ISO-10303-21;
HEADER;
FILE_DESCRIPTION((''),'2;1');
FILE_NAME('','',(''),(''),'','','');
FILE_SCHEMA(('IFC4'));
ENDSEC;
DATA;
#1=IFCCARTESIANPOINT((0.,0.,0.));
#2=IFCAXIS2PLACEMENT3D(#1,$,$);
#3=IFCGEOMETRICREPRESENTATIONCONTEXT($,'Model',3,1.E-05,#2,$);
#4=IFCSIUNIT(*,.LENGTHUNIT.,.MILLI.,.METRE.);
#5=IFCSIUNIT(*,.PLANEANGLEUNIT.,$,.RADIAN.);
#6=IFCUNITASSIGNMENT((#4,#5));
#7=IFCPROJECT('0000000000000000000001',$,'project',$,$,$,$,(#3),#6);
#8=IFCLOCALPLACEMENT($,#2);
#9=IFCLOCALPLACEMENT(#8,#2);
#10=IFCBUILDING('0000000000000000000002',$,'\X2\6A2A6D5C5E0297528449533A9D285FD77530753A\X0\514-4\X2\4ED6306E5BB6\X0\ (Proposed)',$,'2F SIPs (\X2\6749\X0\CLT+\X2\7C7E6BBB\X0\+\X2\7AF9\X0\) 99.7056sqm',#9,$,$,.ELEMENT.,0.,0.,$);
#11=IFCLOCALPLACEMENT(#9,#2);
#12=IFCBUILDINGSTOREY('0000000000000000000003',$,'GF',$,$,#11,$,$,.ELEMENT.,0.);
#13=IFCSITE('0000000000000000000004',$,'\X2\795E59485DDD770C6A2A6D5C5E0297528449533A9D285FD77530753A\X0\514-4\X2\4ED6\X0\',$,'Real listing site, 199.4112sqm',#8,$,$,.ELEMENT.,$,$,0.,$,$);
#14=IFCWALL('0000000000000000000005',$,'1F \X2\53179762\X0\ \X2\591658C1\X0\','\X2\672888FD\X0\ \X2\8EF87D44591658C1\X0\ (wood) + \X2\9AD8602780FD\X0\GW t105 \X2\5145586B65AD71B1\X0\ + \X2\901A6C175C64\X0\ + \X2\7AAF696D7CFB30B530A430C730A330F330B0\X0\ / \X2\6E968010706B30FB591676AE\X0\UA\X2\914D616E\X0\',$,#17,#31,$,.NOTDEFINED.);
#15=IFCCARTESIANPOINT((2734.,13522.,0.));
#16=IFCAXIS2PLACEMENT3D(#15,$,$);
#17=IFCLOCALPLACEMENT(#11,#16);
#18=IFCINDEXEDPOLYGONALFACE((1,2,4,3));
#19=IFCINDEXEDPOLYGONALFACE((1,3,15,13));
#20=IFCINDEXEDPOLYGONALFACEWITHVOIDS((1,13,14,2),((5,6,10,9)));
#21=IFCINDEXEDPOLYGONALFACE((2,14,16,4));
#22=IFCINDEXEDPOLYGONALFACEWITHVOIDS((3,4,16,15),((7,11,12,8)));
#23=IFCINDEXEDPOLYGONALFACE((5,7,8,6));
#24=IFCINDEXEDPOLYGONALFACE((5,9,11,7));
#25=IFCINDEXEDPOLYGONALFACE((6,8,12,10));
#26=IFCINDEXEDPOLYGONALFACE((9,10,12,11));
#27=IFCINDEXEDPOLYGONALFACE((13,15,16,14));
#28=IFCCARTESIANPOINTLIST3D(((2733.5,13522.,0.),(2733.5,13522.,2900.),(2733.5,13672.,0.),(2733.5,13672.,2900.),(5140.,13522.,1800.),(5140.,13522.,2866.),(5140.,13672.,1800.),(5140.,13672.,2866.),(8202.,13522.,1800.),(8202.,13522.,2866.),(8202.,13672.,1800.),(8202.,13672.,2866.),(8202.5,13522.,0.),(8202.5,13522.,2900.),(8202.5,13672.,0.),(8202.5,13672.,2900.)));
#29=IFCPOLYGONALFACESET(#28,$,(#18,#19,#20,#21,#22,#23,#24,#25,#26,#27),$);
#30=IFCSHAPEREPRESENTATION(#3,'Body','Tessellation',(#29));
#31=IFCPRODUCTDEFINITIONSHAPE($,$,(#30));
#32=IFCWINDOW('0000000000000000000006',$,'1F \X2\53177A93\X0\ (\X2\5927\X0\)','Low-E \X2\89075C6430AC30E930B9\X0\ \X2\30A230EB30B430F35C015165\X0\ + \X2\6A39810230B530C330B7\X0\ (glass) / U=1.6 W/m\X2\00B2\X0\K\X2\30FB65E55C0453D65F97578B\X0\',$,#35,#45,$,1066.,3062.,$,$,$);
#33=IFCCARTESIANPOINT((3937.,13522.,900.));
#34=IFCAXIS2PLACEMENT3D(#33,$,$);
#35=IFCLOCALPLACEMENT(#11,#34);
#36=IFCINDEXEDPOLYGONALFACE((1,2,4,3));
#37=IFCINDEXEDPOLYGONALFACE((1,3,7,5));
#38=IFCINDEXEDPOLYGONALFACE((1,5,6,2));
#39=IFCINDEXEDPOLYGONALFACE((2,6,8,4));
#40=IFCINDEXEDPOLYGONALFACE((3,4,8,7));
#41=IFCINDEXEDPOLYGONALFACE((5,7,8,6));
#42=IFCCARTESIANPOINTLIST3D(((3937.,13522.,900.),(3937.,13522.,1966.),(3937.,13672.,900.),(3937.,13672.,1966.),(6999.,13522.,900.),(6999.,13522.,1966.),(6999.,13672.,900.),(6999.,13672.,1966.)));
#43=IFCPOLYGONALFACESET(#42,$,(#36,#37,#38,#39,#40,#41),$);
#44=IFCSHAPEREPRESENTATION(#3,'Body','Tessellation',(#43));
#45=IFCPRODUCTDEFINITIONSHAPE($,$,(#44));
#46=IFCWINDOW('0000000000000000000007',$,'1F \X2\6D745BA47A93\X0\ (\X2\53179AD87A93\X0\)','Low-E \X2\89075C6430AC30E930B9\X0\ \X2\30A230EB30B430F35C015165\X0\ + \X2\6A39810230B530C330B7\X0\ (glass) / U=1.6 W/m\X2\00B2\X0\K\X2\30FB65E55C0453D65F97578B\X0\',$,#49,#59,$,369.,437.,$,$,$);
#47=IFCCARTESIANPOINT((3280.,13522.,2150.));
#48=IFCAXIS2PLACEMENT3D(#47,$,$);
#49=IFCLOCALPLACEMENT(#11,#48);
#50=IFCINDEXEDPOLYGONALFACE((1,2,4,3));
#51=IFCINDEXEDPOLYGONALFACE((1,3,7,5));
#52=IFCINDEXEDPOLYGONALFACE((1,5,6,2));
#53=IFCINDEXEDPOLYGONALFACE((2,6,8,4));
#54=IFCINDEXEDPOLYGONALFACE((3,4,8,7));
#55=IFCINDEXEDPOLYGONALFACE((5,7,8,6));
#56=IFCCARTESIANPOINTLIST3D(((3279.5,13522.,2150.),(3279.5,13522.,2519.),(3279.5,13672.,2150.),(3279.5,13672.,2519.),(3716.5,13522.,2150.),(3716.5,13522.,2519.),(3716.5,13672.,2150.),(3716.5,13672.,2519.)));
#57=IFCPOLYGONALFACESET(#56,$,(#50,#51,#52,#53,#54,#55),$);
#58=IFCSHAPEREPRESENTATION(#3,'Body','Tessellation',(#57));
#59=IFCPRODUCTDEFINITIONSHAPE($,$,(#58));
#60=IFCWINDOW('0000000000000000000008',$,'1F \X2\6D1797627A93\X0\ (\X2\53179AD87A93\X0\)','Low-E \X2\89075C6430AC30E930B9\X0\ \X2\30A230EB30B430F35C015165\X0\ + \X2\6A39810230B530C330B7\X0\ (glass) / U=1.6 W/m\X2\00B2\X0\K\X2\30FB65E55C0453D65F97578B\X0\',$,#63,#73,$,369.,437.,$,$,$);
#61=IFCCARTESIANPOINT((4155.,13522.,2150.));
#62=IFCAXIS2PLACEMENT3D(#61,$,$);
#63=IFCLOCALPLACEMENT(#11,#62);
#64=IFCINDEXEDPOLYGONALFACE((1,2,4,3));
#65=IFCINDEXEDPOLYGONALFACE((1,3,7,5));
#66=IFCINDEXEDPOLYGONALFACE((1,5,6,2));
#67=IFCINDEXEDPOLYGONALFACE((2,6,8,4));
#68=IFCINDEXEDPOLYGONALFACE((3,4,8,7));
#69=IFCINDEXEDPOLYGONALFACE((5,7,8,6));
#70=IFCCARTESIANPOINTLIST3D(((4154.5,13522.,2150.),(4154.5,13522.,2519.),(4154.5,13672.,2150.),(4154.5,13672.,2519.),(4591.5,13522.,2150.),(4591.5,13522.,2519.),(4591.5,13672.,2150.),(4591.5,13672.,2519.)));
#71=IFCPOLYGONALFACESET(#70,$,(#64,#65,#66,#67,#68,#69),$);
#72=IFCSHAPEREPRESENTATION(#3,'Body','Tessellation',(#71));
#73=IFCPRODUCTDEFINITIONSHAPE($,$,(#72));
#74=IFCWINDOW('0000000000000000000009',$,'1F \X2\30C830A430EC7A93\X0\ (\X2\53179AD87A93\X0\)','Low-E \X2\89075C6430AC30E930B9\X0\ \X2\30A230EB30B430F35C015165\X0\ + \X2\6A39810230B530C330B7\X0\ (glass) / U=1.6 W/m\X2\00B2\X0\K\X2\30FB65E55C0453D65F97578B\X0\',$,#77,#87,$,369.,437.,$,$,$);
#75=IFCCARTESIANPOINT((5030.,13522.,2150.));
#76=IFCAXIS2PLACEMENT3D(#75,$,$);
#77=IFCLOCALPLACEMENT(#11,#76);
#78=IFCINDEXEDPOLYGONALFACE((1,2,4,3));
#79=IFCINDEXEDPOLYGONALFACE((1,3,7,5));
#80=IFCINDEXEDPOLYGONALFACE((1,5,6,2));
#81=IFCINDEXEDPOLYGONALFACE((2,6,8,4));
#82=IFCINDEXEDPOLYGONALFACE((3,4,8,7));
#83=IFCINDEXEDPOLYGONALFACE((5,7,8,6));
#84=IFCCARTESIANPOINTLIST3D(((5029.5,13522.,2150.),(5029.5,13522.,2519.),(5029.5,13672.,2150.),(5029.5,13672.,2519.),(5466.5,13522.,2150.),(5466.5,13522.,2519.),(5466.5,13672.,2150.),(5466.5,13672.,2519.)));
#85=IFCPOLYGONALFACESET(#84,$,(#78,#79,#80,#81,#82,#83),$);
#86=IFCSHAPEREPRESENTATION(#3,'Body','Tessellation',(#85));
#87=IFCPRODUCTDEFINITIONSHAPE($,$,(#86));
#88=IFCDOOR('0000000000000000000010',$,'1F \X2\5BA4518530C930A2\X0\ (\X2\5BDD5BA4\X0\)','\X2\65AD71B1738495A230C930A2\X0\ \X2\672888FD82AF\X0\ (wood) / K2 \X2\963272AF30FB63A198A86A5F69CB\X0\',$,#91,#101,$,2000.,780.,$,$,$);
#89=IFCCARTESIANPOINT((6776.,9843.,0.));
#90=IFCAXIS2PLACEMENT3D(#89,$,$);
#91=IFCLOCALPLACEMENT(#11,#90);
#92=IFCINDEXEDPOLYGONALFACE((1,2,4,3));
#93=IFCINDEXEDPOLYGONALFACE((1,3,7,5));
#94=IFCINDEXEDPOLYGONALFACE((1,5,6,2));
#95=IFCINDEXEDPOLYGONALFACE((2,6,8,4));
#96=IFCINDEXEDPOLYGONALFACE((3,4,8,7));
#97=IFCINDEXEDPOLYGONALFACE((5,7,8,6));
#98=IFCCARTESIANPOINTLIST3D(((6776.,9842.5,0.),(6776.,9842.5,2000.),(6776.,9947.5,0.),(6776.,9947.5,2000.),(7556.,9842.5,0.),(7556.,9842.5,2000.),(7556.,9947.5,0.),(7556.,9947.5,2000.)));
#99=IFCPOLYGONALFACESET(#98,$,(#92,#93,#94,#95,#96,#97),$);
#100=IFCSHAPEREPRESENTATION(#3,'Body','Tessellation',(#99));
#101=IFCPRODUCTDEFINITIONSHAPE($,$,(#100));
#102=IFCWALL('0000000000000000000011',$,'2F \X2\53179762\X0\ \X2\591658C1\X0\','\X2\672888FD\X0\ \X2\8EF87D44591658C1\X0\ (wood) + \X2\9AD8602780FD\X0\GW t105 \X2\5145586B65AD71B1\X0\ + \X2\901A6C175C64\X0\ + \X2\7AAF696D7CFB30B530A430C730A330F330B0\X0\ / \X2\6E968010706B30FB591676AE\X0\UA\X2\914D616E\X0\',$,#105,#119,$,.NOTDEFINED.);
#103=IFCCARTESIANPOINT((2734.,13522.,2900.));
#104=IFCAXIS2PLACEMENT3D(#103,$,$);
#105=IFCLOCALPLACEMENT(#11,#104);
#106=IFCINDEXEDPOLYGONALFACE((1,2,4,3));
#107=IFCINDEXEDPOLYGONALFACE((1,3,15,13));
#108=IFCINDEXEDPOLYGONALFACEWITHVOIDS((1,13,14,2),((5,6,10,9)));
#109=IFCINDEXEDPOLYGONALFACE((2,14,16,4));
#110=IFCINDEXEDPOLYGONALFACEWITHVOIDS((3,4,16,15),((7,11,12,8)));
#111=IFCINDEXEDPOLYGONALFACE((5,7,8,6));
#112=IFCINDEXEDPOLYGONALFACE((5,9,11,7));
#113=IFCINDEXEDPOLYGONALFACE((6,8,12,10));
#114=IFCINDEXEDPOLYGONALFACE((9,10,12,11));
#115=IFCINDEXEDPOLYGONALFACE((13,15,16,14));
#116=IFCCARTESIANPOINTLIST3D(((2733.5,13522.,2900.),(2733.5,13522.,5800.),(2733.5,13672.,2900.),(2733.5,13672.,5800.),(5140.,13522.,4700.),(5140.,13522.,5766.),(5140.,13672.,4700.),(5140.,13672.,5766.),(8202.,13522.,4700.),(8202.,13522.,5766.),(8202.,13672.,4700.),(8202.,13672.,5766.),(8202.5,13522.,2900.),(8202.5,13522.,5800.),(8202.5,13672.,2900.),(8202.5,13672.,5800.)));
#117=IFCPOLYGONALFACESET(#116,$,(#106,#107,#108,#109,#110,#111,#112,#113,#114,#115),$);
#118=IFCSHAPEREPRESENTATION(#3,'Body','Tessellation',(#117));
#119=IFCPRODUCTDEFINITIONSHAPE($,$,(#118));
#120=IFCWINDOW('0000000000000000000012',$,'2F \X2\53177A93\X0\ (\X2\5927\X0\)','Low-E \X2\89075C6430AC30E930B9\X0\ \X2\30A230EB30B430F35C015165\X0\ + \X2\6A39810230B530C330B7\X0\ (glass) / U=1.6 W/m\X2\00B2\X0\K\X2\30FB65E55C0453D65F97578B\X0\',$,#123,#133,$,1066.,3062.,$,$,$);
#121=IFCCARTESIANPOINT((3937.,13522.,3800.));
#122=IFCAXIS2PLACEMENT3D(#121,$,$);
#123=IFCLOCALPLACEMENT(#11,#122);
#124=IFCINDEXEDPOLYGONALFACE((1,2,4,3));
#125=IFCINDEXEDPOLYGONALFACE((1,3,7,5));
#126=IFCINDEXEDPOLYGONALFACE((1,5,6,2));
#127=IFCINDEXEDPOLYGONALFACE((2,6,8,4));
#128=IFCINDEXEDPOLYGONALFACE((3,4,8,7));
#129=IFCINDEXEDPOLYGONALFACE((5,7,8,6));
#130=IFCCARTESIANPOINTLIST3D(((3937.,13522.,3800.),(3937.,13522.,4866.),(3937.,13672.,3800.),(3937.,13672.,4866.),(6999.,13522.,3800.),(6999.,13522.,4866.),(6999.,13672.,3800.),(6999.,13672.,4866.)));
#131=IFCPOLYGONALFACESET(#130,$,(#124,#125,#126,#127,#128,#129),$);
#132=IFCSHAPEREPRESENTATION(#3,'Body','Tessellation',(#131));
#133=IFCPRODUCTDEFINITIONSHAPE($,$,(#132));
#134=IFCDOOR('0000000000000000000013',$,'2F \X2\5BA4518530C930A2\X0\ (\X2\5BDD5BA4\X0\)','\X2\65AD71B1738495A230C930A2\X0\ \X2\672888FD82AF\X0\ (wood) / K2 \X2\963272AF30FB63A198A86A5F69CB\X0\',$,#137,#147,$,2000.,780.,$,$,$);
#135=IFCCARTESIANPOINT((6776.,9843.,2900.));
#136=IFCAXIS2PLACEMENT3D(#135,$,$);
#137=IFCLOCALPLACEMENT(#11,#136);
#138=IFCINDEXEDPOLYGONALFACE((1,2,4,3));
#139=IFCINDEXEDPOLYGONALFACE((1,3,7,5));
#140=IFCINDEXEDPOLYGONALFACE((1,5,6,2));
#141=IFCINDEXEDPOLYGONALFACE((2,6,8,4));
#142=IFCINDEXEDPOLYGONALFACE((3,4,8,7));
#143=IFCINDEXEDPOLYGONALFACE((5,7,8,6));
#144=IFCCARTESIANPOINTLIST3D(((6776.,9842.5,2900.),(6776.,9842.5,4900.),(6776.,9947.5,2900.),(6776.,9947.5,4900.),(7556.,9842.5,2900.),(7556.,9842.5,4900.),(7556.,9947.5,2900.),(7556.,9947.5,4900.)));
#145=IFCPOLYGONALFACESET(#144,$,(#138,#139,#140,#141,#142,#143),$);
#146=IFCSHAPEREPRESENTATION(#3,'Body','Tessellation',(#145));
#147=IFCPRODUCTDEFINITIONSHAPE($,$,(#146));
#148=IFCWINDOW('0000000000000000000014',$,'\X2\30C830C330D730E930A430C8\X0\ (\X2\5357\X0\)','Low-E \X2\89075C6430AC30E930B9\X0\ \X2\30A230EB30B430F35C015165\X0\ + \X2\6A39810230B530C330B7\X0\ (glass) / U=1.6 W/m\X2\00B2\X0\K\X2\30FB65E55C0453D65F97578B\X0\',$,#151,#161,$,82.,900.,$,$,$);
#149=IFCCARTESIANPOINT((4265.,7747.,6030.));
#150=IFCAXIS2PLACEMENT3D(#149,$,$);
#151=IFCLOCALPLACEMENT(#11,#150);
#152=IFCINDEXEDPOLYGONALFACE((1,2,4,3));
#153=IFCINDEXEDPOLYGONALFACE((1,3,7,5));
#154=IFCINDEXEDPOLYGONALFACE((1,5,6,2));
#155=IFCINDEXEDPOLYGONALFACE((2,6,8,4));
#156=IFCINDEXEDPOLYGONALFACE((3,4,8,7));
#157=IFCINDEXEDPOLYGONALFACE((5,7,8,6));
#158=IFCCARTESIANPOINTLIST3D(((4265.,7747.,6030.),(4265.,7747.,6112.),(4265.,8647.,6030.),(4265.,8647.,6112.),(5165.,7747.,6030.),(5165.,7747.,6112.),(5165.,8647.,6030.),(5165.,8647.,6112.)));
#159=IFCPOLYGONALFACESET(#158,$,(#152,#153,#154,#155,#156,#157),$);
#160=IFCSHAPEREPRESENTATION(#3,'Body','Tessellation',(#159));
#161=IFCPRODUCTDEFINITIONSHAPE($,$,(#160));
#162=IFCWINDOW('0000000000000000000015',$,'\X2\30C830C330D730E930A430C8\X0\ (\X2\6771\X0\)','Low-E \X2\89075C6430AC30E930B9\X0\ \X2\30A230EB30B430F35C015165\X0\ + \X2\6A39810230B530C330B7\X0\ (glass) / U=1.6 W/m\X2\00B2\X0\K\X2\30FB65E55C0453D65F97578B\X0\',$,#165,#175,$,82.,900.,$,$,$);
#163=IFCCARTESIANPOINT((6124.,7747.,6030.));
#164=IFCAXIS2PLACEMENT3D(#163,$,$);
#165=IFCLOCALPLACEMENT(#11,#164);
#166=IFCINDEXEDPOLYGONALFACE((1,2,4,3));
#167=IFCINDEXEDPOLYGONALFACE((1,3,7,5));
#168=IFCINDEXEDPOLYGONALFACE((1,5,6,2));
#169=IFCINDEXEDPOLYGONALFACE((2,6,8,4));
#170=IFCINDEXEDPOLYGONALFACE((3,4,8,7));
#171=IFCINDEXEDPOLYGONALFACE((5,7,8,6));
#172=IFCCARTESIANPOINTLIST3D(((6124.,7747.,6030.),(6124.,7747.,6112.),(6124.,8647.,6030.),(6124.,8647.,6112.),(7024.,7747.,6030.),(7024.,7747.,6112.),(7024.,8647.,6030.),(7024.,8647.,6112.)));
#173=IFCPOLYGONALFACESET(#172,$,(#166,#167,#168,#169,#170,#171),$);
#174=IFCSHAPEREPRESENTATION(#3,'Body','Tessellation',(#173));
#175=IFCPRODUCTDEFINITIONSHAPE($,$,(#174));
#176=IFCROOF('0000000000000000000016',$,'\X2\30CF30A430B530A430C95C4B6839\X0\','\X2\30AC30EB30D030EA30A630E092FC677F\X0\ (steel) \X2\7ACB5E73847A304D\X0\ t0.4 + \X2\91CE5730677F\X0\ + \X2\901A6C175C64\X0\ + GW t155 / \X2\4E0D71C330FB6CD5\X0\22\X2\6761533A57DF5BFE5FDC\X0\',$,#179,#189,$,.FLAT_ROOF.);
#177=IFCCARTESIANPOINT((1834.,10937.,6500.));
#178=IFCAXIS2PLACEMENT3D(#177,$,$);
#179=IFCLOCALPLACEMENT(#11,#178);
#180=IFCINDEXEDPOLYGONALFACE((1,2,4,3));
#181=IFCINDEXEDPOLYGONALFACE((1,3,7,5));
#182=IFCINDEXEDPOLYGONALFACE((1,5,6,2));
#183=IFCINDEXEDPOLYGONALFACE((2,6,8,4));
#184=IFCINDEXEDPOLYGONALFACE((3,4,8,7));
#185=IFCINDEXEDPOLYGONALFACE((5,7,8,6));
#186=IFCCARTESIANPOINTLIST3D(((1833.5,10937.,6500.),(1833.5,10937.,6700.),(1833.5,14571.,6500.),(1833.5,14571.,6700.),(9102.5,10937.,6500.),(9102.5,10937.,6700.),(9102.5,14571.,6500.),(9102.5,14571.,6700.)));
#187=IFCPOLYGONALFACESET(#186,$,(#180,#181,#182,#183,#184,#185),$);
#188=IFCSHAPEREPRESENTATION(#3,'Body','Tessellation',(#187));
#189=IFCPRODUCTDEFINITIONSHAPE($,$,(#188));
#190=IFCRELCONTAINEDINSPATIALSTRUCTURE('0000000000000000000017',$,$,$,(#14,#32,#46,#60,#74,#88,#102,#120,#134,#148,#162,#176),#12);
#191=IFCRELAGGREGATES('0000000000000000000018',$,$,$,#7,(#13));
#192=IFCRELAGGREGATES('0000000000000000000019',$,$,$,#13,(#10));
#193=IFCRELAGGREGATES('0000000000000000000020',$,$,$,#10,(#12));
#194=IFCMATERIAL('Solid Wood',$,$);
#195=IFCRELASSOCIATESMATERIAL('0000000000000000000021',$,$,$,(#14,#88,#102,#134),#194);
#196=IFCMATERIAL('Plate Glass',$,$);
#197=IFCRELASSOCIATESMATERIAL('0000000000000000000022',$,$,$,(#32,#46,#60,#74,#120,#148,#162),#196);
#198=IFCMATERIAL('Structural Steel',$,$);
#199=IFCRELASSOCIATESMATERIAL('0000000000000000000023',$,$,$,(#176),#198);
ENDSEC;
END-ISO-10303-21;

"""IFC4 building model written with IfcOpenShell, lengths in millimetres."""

from ifc_helpers import new_model, si_unit, frame, frame_2d, origin, place, context, project, spatial, rectangle, extrude, material, element, fill, save


model = new_model("IFC4")

# Units and contexts
model_context = context("Model", 3, precision=1e-05, world=origin())
ifc_project = project(units=[si_unit("LENGTHUNIT", "METRE", prefix="MILLI"), si_unit("PLANEANGLEUNIT", "RADIAN")], contexts=[model_context])

# Site, building, storey
site_placement = place(None, origin())
site = spatial("IfcSite", under=ifc_project, at=site_placement, Name="神奈川県横浜市青葉区鴨志田町514-4他", ObjectType="Real listing site, 199.4112sqm", CompositionType="ELEMENT", RefElevation=0.0)
building_placement = place(site_placement, origin())
building = spatial("IfcBuilding", under=site, at=building_placement, Name="横浜市青葉区鴨志田町514-4他の家 (Proposed)", ObjectType="2F SIPs (杉CLT+籾殻+竹) 99.7056sqm", CompositionType="ELEMENT", ElevationOfRefHeight=0.0, ElevationOfTerrain=0.0)
storey_placement = place(building_placement, origin())
storey = spatial("IfcBuildingStorey", under=building, at=storey_placement, Name="GF", CompositionType="ELEMENT", Elevation=0.0)

# Wall, openings, windows
ifc_material_1 = material(Name="Solid Wood")
wall_1_placement = place(storey_placement, frame((2734.0, 13522.0, 0.0)))
wall_1 = element("IfcWall", 1, at=wall_1_placement, inside=storey, material=ifc_material_1, Name="1F 北面 外壁", Description="木製 軸組外壁 (wood) + 高性能GW t105 充填断熱 + 通気層 + 窯業系サイディング / 準耐火・外皮UA配慮", PredefinedType="NOTDEFINED", context=model_context, shape_type="SweptSolid", body=[
    extrude(rectangle(XDim=5469.0, YDim=150.0, at=frame_2d((2734.0, 75.0))), frame((2734.0, 13522.0, 0.0)), (0.0, 0.0, 1.0), 2900.0),
])
opening_1_placement = place(storey_placement, frame((3937.0, 13522.0, 900.0)))
opening_1 = element("IfcOpeningElement", 2, at=opening_1_placement, cuts=wall_1, PredefinedType="NOTDEFINED", context=model_context, shape_type="SweptSolid", body=[
    extrude(rectangle(XDim=3062.0, YDim=150.0, at=frame_2d((1531.0, 75.0))), frame((3937.0, 13522.0, 900.0)), (0.0, 0.0, 1.0), 1066.0),
])
opening_2_placement = place(storey_placement, frame((3280.0, 13522.0, 2150.0)))
opening_2 = element("IfcOpeningElement", 3, at=opening_2_placement, cuts=wall_1, PredefinedType="NOTDEFINED", context=model_context, shape_type="SweptSolid", body=[
    extrude(rectangle(XDim=437.0, YDim=150.0, at=frame_2d((218.0, 75.0))), frame((3280.0, 13522.0, 2150.0)), (0.0, 0.0, 1.0), 369.0),
])
opening_3_placement = place(storey_placement, frame((4155.0, 13522.0, 2150.0)))
opening_3 = element("IfcOpeningElement", 4, at=opening_3_placement, cuts=wall_1, PredefinedType="NOTDEFINED", context=model_context, shape_type="SweptSolid", body=[
    extrude(rectangle(XDim=437.0, YDim=150.0, at=frame_2d((218.0, 75.0))), frame((4155.0, 13522.0, 2150.0)), (0.0, 0.0, 1.0), 369.0),
])
opening_4_placement = place(storey_placement, frame((5030.0, 13522.0, 2150.0)))
opening_4 = element("IfcOpeningElement", 5, at=opening_4_placement, cuts=wall_1, PredefinedType="NOTDEFINED", context=model_context, shape_type="SweptSolid", body=[
    extrude(rectangle(XDim=437.0, YDim=150.0, at=frame_2d((218.0, 75.0))), frame((5030.0, 13522.0, 2150.0)), (0.0, 0.0, 1.0), 369.0),
])
ifc_material_2 = material(Name="Plate Glass")
window_1_placement = place(storey_placement, frame((3937.0, 13522.0, 900.0)))
window_1 = element("IfcWindow", 6, at=window_1_placement, inside=storey, material=ifc_material_2, Name="1F 北窓 (大)", Description="Low-E 複層ガラス アルゴン封入 + 樹脂サッシ (glass) / U=1.6 W/m²K・日射取得型", OverallHeight=1066.0, OverallWidth=3062.0, context=model_context, shape_type="SweptSolid", body=[
    extrude(rectangle(XDim=3062.0, YDim=150.0, at=frame_2d((1531.0, 75.0))), frame((3937.0, 13522.0, 900.0)), (0.0, 0.0, 1.0), 1066.0),
])
fill(opening_1, window_1)
window_2_placement = place(storey_placement, frame((3280.0, 13522.0, 2150.0)))
window_2 = element("IfcWindow", 7, at=window_2_placement, inside=storey, material=ifc_material_2, Name="1F 浴室窓 (北高窓)", Description="Low-E 複層ガラス アルゴン封入 + 樹脂サッシ (glass) / U=1.6 W/m²K・日射取得型", OverallHeight=369.0, OverallWidth=437.0, context=model_context, shape_type="SweptSolid", body=[
    extrude(rectangle(XDim=437.0, YDim=150.0, at=frame_2d((218.0, 75.0))), frame((3280.0, 13522.0, 2150.0)), (0.0, 0.0, 1.0), 369.0),
])
fill(opening_2, window_2)
window_3_placement = place(storey_placement, frame((4155.0, 13522.0, 2150.0)))
window_3 = element("IfcWindow", 8, at=window_3_placement, inside=storey, material=ifc_material_2, Name="1F 洗面窓 (北高窓)", Description="Low-E 複層ガラス アルゴン封入 + 樹脂サッシ (glass) / U=1.6 W/m²K・日射取得型", OverallHeight=369.0, OverallWidth=437.0, context=model_context, shape_type="SweptSolid", body=[
    extrude(rectangle(XDim=437.0, YDim=150.0, at=frame_2d((218.0, 75.0))), frame((4155.0, 13522.0, 2150.0)), (0.0, 0.0, 1.0), 369.0),
])
fill(opening_3, window_3)
window_4_placement = place(storey_placement, frame((5030.0, 13522.0, 2150.0)))
window_4 = element("IfcWindow", 9, at=window_4_placement, inside=storey, material=ifc_material_2, Name="1F トイレ窓 (北高窓)", Description="Low-E 複層ガラス アルゴン封入 + 樹脂サッシ (glass) / U=1.6 W/m²K・日射取得型", OverallHeight=369.0, OverallWidth=437.0, context=model_context, shape_type="SweptSolid", body=[
    extrude(rectangle(XDim=437.0, YDim=150.0, at=frame_2d((218.0, 75.0))), frame((5030.0, 13522.0, 2150.0)), (0.0, 0.0, 1.0), 369.0),
])
fill(opening_4, window_4)

# Door
door_1_placement = place(storey_placement, frame((6776.0, 9843.0, 0.0)))
element("IfcDoor", 10, at=door_1_placement, inside=storey, material=ifc_material_1, Name="1F 室内ドア (寝室)", Description="断熱玄関ドア 木製芯 (wood) / K2 防犯・採風機構", OverallHeight=2000.0, OverallWidth=780.0, context=model_context, shape_type="SweptSolid", body=[
    extrude(rectangle(XDim=780.0, YDim=105.0, at=frame_2d((390.0, 52.0))), frame((6776.0, 9843.0, 0.0)), (0.0, 0.0, 1.0), 2000.0),
])

# Wall, opening, window
wall_2_placement = place(storey_placement, frame((2734.0, 13522.0, 2900.0)))
wall_2 = element("IfcWall", 11, at=wall_2_placement, inside=storey, material=ifc_material_1, Name="2F 北面 外壁", Description="木製 軸組外壁 (wood) + 高性能GW t105 充填断熱 + 通気層 + 窯業系サイディング / 準耐火・外皮UA配慮", PredefinedType="NOTDEFINED", context=model_context, shape_type="SweptSolid", body=[
    extrude(rectangle(XDim=5469.0, YDim=150.0, at=frame_2d((2734.0, 75.0))), frame((2734.0, 13522.0, 2900.0)), (0.0, 0.0, 1.0), 2900.0),
])
opening_5_placement = place(storey_placement, frame((3937.0, 13522.0, 3800.0)))
opening_5 = element("IfcOpeningElement", 12, at=opening_5_placement, cuts=wall_2, PredefinedType="NOTDEFINED", context=model_context, shape_type="SweptSolid", body=[
    extrude(rectangle(XDim=3062.0, YDim=150.0, at=frame_2d((1531.0, 75.0))), frame((3937.0, 13522.0, 3800.0)), (0.0, 0.0, 1.0), 1066.0),
])
window_5_placement = place(storey_placement, frame((3937.0, 13522.0, 3800.0)))
window_5 = element("IfcWindow", 13, at=window_5_placement, inside=storey, material=ifc_material_2, Name="2F 北窓 (大)", Description="Low-E 複層ガラス アルゴン封入 + 樹脂サッシ (glass) / U=1.6 W/m²K・日射取得型", OverallHeight=1066.0, OverallWidth=3062.0, context=model_context, shape_type="SweptSolid", body=[
    extrude(rectangle(XDim=3062.0, YDim=150.0, at=frame_2d((1531.0, 75.0))), frame((3937.0, 13522.0, 3800.0)), (0.0, 0.0, 1.0), 1066.0),
])
fill(opening_5, window_5)

# Door
door_2_placement = place(storey_placement, frame((6776.0, 9843.0, 2900.0)))
element("IfcDoor", 14, at=door_2_placement, inside=storey, material=ifc_material_1, Name="2F 室内ドア (寝室)", Description="断熱玄関ドア 木製芯 (wood) / K2 防犯・採風機構", OverallHeight=2000.0, OverallWidth=780.0, context=model_context, shape_type="SweptSolid", body=[
    extrude(rectangle(XDim=780.0, YDim=105.0, at=frame_2d((390.0, 52.0))), frame((6776.0, 9843.0, 2900.0)), (0.0, 0.0, 1.0), 2000.0),
])

# Windows
window_6_placement = place(storey_placement, frame((4265.0, 7747.0, 6030.0)))
element("IfcWindow", 15, at=window_6_placement, inside=storey, material=ifc_material_2, Name="トップライト (南)", Description="Low-E 複層ガラス アルゴン封入 + 樹脂サッシ (glass) / U=1.6 W/m²K・日射取得型", OverallHeight=82.0, OverallWidth=900.0, context=model_context, shape_type="SweptSolid", body=[
    extrude(rectangle(XDim=900.0, YDim=900.0, at=frame_2d((450.0, 450.0))), frame((4265.0, 7747.0, 6030.0)), (0.0, 0.0, 1.0), 82.0),
])
window_7_placement = place(storey_placement, frame((6124.0, 7747.0, 6030.0)))
element("IfcWindow", 16, at=window_7_placement, inside=storey, material=ifc_material_2, Name="トップライト (東)", Description="Low-E 複層ガラス アルゴン封入 + 樹脂サッシ (glass) / U=1.6 W/m²K・日射取得型", OverallHeight=82.0, OverallWidth=900.0, context=model_context, shape_type="SweptSolid", body=[
    extrude(rectangle(XDim=900.0, YDim=900.0, at=frame_2d((450.0, 450.0))), frame((6124.0, 7747.0, 6030.0)), (0.0, 0.0, 1.0), 82.0),
])

# Roof
ifc_material_3 = material(Name="Structural Steel")
roof_placement = place(storey_placement, frame((1834.0, 10937.0, 6500.0)))
element("IfcRoof", 17, at=roof_placement, inside=storey, material=ifc_material_3, Name="ハイサイド屋根", Description="ガルバリウム鋼板 (steel) 立平葺き t0.4 + 野地板 + 通気層 + GW t155 / 不燃・法22条区域対応", PredefinedType="FLAT_ROOF", context=model_context, shape_type="SweptSolid", body=[
    extrude(rectangle(XDim=7269.0, YDim=3634.0, at=frame_2d((3634.0, 1817.0))), frame((1834.0, 10937.0, 6500.0)), (0.0, 0.0, 1.0), 200.0),
])

save(model, "model.ifc")
